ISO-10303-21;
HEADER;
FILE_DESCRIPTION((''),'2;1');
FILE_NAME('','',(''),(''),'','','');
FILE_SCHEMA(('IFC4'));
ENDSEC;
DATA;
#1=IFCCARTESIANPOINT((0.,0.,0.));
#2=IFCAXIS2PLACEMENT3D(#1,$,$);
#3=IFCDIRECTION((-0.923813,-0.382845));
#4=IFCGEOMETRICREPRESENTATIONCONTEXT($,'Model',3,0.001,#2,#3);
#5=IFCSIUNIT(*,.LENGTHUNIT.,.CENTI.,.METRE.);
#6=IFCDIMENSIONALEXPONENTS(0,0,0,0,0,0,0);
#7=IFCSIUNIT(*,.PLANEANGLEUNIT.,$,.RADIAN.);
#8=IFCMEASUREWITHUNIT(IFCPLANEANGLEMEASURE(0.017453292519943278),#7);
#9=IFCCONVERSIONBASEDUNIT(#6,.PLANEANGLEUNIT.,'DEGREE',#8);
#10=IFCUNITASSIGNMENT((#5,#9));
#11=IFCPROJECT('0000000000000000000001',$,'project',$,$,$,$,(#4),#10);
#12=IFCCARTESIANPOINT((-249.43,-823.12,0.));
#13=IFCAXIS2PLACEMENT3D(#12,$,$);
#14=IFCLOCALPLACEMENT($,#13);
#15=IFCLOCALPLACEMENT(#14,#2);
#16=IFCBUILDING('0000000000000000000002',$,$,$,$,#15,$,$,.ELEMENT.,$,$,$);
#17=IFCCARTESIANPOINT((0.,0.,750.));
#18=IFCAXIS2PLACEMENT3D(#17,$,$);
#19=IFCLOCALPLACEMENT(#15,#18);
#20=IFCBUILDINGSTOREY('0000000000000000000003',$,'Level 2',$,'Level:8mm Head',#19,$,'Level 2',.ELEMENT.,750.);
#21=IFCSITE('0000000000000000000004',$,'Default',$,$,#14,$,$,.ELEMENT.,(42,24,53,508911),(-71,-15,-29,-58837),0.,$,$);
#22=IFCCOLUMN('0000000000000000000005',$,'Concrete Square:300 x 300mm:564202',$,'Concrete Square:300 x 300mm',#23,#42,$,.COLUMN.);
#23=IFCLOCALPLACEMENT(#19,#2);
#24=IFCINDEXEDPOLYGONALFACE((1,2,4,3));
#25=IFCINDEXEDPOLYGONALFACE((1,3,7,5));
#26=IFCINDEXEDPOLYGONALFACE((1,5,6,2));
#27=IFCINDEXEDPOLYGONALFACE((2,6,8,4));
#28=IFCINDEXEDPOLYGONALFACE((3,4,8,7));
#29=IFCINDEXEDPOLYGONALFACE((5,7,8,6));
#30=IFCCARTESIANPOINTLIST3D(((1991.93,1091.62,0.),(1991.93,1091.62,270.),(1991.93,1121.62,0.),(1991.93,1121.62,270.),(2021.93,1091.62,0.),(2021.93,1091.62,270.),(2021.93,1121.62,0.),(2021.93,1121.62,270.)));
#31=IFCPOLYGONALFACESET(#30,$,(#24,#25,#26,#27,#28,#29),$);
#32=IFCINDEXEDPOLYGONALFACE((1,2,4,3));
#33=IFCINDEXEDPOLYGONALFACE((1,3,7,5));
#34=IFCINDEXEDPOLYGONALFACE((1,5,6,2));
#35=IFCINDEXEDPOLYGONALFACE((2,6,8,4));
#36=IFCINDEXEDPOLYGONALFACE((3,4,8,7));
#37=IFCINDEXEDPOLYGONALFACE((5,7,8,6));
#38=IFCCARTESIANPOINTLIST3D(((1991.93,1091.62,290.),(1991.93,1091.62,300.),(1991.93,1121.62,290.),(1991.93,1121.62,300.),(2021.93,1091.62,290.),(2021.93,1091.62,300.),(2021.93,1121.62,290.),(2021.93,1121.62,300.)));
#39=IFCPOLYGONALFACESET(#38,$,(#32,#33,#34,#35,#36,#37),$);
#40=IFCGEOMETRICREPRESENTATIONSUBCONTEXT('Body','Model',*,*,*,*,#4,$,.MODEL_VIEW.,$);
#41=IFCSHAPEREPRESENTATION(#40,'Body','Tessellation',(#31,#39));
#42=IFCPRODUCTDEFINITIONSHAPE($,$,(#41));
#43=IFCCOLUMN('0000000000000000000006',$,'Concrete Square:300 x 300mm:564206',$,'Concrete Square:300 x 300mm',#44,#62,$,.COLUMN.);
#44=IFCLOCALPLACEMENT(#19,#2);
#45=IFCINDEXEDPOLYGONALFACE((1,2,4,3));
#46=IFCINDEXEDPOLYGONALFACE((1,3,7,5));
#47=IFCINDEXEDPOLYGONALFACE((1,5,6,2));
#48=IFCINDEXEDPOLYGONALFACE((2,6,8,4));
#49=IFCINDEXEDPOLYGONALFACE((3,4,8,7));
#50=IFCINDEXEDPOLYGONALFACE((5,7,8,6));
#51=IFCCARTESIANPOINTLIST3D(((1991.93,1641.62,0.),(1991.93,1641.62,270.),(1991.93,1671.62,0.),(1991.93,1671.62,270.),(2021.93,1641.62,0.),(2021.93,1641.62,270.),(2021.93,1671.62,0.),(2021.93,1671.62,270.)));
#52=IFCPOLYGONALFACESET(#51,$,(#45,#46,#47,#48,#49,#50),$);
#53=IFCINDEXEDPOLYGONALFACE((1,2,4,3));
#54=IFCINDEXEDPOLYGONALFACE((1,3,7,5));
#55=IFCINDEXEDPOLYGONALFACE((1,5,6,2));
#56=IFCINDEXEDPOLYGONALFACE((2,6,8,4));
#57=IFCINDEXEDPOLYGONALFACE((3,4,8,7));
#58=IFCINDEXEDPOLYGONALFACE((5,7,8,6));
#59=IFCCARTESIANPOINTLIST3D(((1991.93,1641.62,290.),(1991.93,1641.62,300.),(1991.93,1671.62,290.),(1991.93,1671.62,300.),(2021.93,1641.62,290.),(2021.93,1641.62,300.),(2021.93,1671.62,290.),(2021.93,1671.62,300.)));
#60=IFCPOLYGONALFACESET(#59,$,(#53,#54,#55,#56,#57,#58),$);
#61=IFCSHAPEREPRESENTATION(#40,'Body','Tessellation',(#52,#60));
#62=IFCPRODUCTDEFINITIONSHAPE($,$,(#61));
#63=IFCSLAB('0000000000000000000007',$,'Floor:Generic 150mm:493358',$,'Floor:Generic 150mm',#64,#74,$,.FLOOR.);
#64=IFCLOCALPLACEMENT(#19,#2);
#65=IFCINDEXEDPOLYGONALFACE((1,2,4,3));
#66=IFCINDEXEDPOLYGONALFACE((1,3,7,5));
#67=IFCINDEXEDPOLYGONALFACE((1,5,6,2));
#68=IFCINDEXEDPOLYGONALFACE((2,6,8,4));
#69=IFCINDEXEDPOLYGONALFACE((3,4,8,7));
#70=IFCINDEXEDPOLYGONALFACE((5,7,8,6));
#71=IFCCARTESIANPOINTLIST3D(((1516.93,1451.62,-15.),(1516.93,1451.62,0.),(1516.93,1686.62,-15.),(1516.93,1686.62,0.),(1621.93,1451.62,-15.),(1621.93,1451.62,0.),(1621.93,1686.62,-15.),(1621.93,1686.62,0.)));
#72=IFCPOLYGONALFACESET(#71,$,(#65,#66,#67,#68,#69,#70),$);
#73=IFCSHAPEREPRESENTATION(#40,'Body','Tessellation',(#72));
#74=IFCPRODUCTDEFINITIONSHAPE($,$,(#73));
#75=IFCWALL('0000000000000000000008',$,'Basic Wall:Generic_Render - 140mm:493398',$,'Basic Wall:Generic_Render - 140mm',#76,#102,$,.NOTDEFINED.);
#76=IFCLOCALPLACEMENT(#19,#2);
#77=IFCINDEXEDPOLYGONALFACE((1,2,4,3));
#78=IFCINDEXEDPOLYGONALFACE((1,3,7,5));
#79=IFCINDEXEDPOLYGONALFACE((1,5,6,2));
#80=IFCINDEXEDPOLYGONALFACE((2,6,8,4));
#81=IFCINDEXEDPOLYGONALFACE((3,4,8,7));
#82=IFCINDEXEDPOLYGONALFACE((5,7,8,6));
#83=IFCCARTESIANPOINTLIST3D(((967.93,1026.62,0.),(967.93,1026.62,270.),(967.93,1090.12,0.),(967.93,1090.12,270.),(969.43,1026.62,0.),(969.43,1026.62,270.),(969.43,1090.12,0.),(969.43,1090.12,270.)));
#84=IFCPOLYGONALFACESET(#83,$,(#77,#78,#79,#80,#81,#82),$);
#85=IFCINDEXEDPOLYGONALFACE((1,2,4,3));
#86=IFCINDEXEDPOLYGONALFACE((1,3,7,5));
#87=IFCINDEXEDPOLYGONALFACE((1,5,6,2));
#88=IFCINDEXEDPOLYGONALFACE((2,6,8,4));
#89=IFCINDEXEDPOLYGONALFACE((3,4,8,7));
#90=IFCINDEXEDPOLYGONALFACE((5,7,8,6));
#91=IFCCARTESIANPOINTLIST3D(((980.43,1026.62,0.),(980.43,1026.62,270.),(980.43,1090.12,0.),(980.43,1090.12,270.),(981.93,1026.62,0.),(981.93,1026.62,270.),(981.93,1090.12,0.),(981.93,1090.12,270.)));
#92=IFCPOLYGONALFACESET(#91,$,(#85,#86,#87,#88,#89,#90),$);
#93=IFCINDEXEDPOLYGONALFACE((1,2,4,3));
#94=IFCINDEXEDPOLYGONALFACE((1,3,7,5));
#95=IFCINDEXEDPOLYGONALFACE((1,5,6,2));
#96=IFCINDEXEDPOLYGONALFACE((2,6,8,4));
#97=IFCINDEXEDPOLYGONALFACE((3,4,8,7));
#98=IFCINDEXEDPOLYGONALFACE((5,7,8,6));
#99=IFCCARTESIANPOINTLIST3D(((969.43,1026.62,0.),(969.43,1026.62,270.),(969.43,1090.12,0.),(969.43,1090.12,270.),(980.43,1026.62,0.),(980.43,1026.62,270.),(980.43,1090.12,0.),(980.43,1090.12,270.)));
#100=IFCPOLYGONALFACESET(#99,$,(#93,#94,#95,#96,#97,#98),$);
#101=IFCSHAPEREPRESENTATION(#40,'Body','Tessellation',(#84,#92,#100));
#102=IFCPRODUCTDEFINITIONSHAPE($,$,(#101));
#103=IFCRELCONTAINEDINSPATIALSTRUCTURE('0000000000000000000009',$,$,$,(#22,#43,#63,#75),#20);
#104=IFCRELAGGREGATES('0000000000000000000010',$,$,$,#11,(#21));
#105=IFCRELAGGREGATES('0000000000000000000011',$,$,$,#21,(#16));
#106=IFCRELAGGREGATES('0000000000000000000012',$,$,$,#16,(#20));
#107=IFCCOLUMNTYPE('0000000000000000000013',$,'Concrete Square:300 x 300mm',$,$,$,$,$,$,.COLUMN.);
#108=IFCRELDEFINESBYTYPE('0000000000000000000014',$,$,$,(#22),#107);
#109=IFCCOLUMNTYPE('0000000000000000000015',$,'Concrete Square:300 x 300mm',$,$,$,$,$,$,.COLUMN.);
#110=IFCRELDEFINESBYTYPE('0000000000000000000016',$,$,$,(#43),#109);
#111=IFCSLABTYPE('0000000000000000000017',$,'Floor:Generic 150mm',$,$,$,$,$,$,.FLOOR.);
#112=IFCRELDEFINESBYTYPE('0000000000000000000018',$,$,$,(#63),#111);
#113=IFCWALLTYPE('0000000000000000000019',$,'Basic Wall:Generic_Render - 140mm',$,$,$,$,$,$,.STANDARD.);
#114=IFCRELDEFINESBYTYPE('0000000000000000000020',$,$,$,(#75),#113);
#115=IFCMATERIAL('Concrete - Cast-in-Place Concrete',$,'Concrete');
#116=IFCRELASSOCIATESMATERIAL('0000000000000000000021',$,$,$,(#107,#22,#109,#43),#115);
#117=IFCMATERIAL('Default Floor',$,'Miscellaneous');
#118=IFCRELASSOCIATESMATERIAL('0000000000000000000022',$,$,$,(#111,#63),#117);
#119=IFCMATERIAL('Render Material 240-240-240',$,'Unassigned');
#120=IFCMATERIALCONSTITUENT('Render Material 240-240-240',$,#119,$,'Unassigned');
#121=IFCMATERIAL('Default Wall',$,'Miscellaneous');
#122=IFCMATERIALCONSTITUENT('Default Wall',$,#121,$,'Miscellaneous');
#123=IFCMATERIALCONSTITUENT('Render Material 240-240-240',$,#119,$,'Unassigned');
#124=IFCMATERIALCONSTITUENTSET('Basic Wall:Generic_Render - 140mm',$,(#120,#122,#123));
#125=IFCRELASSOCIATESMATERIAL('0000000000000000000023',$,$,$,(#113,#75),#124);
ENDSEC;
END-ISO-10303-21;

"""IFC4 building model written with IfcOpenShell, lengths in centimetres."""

from ifc_helpers import new_model, entity, si_unit, converted_unit, direction, frame, origin, place, context, subcontext, project, spatial, indexed_curve, outline, extrude, source, transform, mapped, material, constituent, constituent_set, type_object, type_shapes, element, save


model = new_model("IFC4")

# Units and contexts
model_context = context("Model", 3, precision=0.001, world=origin(), true_north=direction((-0.923813, -0.382845)))
body_context = subcontext(model_context, "Body", "Model", "MODEL_VIEW")
ifc_project = project(units=[si_unit("LENGTHUNIT", "METRE", prefix="CENTI"), converted_unit("PLANEANGLEUNIT", "DEGREE", entity("IfcPlaneAngleMeasure", 0.017453292519943278), si_unit("PLANEANGLEUNIT", "RADIAN"), dimensions=[0, 0, 0, 0, 0, 0, 0])], contexts=[model_context])

# Site, building, storey
site_placement = place(None, frame((-249.43, -823.12, 0.0)))
site = spatial("IfcSite", under=ifc_project, at=site_placement, Name="Default", CompositionType="ELEMENT", RefLatitude=(42, 24, 53, 508911), RefLongitude=(-71, -15, -29, -58837), RefElevation=0.0)
building_placement = place(site_placement, origin())
building = spatial("IfcBuilding", under=site, at=building_placement, CompositionType="ELEMENT")
storey_placement = place(building_placement, frame((0.0, 0.0, 750.0)))
storey = spatial("IfcBuildingStorey", under=building, at=storey_placement, Name="Level 2", ObjectType="Level:8mm Head", LongName="Level 2", CompositionType="ELEMENT", Elevation=750.0)

# Columns
ifc_material_1 = material(Name="Concrete - Cast-in-Place Concrete", Category="Concrete")
column_type_1 = type_object("IfcColumnType", Name="Concrete Square:300 x 300mm", PredefinedType="COLUMN", material=ifc_material_1)
shared_shape_1 = source(origin(), body_context, "Body", "SweptSolid", [
    extrude(outline(indexed_curve([(-15.0, -15.0), (15.0, -15.0), (15.0, 15.0), (-15.0, 15.0), (-15.0, -15.0)], self_intersect=False)), frame((2006.93, 1106.62, 750.0), z_axis=(0.0, 0.0, 1.0), x_axis=(-1.0, 0.0, 0.0)), (0.0, 0.0, 1.0), 270.0),
    extrude(outline(indexed_curve([(-15.0, -15.0), (15.0, -15.0), (15.0, 15.0), (-15.0, 15.0), (-15.0, -15.0)], self_intersect=False)), frame((2006.93, 1106.62, 1040.0), z_axis=(0.0, 0.0, 1.0), x_axis=(-1.0, 0.0, 0.0)), (0.0, 0.0, 1.0), 10.0),
])
type_shapes(column_type_1, [shared_shape_1])
column_1_placement = place(storey_placement, frame((0.0, 0.0, -750.0)))
element("IfcColumn", 1, at=column_1_placement, inside=storey, type_object=column_type_1, material=ifc_material_1, Name="Concrete Square:300 x 300mm:564202", ObjectType="Concrete Square:300 x 300mm", PredefinedType="COLUMN", context=body_context, shape_type="MappedRepresentation", body=[
    mapped(shared_shape_1, transform((0.0, 0.0, 0.0), scale=1.0)),
])
column_type_2 = type_object("IfcColumnType", Name="Concrete Square:300 x 300mm", PredefinedType="COLUMN", material=ifc_material_1)
shared_shape_2 = source(origin(), body_context, "Body", "SweptSolid", [
    extrude(outline(indexed_curve([(-15.0, -15.0), (15.0, -15.0), (15.0, 15.0), (-15.0, 15.0), (-15.0, -15.0)], self_intersect=False)), frame((2006.93, 1656.62, 750.0), z_axis=(0.0, 0.0, 1.0), x_axis=(-1.0, 0.0, 0.0)), (0.0, 0.0, 1.0), 270.0),
    extrude(outline(indexed_curve([(-15.0, -15.0), (15.0, -15.0), (15.0, 15.0), (-15.0, 15.0), (-15.0, -15.0)], self_intersect=False)), frame((2006.93, 1656.62, 1040.0), z_axis=(0.0, 0.0, 1.0), x_axis=(-1.0, 0.0, 0.0)), (0.0, 0.0, 1.0), 10.0),
])
type_shapes(column_type_2, [shared_shape_2])
column_2_placement = place(storey_placement, frame((0.0, 0.0, -750.0)))
element("IfcColumn", 2, at=column_2_placement, inside=storey, type_object=column_type_2, material=ifc_material_1, Name="Concrete Square:300 x 300mm:564206", ObjectType="Concrete Square:300 x 300mm", PredefinedType="COLUMN", context=body_context, shape_type="MappedRepresentation", body=[
    mapped(shared_shape_2, transform((0.0, 0.0, 0.0), scale=1.0)),
])

# Slab
ifc_material_2 = material(Name="Default Floor", Category="Miscellaneous")
slab_type_1 = type_object("IfcSlabType", Name="Floor:Generic 150mm", PredefinedType="FLOOR", material=ifc_material_2)
slab_1_placement = place(storey_placement, origin())
element("IfcSlab", 3, at=slab_1_placement, inside=storey, type_object=slab_type_1, material=ifc_material_2, Name="Floor:Generic 150mm:493358", ObjectType="Floor:Generic 150mm", PredefinedType="FLOOR", context=body_context, shape_type="SweptSolid", body=[
    extrude(outline(indexed_curve([(-117.5, -52.5), (117.5, -52.5), (117.5, 52.5), (-117.5, 52.5), (-117.5, -52.5)], self_intersect=False)), frame((1569.43, 1569.12, 0.0), z_axis=(0.0, 0.0, -1.0), x_axis=(0.0, 1.0, 0.0)), (0.0, 0.0, 1.0), 15.0),
])

# Wall
ifc_material_3 = material(Name="Render Material 240-240-240", Category="Unassigned")
ifc_constituent_1 = constituent(ifc_material_3, Name="Render Material 240-240-240", Category="Unassigned")
ifc_material_4 = material(Name="Default Wall", Category="Miscellaneous")
ifc_constituent_2 = constituent(ifc_material_4, Name="Default Wall", Category="Miscellaneous")
ifc_constituent_3 = constituent(ifc_material_3, Name="Render Material 240-240-240", Category="Unassigned")
ifc_constituent_set_1 = constituent_set(constituents=[ifc_constituent_1, ifc_constituent_2, ifc_constituent_3], Name="Basic Wall:Generic_Render - 140mm")
wall_type_1 = type_object("IfcWallType", Name="Basic Wall:Generic_Render - 140mm", PredefinedType="STANDARD", material=ifc_constituent_set_1)
wall_1_placement = place(storey_placement, frame((974.93, 1090.12, 0.0), z_axis=(0.0, 0.0, 1.0), x_axis=(0.0, -1.0, 0.0)))
element("IfcWall", 4, at=wall_1_placement, inside=storey, type_object=wall_type_1, material=ifc_constituent_set_1, Name="Basic Wall:Generic_Render - 140mm:493398", ObjectType="Basic Wall:Generic_Render - 140mm", PredefinedType="NOTDEFINED", context=body_context, shape_type="SweptSolid", body=[
    extrude(outline(indexed_curve([(-0.75, -31.75), (0.75, -31.75), (0.75, 31.75), (-0.75, 31.75), (-0.75, -31.75)], self_intersect=False)), frame((31.75, -6.25, 0.0), z_axis=(0.0, 0.0, 1.0), x_axis=(0.0, 1.0, 0.0)), (0.0, 0.0, 1.0), 270.0),
    extrude(outline(indexed_curve([(-0.75, -31.75), (0.75, -31.75), (0.75, 31.75), (-0.75, 31.75), (-0.75, -31.75)], self_intersect=False)), frame((31.75, 6.25, 0.0), z_axis=(0.0, 0.0, 1.0), x_axis=(0.0, -1.0, 0.0)), (0.0, 0.0, 1.0), 270.0),
    extrude(outline(indexed_curve([(-31.75, -5.5), (31.75, -5.5), (31.75, 5.5), (-31.75, 5.5), (-31.75, -5.5)], self_intersect=False)), frame((31.75, 0.0, 0.0)), (0.0, 0.0, 1.0), 270.0),
])

save(model, "model.ifc")
